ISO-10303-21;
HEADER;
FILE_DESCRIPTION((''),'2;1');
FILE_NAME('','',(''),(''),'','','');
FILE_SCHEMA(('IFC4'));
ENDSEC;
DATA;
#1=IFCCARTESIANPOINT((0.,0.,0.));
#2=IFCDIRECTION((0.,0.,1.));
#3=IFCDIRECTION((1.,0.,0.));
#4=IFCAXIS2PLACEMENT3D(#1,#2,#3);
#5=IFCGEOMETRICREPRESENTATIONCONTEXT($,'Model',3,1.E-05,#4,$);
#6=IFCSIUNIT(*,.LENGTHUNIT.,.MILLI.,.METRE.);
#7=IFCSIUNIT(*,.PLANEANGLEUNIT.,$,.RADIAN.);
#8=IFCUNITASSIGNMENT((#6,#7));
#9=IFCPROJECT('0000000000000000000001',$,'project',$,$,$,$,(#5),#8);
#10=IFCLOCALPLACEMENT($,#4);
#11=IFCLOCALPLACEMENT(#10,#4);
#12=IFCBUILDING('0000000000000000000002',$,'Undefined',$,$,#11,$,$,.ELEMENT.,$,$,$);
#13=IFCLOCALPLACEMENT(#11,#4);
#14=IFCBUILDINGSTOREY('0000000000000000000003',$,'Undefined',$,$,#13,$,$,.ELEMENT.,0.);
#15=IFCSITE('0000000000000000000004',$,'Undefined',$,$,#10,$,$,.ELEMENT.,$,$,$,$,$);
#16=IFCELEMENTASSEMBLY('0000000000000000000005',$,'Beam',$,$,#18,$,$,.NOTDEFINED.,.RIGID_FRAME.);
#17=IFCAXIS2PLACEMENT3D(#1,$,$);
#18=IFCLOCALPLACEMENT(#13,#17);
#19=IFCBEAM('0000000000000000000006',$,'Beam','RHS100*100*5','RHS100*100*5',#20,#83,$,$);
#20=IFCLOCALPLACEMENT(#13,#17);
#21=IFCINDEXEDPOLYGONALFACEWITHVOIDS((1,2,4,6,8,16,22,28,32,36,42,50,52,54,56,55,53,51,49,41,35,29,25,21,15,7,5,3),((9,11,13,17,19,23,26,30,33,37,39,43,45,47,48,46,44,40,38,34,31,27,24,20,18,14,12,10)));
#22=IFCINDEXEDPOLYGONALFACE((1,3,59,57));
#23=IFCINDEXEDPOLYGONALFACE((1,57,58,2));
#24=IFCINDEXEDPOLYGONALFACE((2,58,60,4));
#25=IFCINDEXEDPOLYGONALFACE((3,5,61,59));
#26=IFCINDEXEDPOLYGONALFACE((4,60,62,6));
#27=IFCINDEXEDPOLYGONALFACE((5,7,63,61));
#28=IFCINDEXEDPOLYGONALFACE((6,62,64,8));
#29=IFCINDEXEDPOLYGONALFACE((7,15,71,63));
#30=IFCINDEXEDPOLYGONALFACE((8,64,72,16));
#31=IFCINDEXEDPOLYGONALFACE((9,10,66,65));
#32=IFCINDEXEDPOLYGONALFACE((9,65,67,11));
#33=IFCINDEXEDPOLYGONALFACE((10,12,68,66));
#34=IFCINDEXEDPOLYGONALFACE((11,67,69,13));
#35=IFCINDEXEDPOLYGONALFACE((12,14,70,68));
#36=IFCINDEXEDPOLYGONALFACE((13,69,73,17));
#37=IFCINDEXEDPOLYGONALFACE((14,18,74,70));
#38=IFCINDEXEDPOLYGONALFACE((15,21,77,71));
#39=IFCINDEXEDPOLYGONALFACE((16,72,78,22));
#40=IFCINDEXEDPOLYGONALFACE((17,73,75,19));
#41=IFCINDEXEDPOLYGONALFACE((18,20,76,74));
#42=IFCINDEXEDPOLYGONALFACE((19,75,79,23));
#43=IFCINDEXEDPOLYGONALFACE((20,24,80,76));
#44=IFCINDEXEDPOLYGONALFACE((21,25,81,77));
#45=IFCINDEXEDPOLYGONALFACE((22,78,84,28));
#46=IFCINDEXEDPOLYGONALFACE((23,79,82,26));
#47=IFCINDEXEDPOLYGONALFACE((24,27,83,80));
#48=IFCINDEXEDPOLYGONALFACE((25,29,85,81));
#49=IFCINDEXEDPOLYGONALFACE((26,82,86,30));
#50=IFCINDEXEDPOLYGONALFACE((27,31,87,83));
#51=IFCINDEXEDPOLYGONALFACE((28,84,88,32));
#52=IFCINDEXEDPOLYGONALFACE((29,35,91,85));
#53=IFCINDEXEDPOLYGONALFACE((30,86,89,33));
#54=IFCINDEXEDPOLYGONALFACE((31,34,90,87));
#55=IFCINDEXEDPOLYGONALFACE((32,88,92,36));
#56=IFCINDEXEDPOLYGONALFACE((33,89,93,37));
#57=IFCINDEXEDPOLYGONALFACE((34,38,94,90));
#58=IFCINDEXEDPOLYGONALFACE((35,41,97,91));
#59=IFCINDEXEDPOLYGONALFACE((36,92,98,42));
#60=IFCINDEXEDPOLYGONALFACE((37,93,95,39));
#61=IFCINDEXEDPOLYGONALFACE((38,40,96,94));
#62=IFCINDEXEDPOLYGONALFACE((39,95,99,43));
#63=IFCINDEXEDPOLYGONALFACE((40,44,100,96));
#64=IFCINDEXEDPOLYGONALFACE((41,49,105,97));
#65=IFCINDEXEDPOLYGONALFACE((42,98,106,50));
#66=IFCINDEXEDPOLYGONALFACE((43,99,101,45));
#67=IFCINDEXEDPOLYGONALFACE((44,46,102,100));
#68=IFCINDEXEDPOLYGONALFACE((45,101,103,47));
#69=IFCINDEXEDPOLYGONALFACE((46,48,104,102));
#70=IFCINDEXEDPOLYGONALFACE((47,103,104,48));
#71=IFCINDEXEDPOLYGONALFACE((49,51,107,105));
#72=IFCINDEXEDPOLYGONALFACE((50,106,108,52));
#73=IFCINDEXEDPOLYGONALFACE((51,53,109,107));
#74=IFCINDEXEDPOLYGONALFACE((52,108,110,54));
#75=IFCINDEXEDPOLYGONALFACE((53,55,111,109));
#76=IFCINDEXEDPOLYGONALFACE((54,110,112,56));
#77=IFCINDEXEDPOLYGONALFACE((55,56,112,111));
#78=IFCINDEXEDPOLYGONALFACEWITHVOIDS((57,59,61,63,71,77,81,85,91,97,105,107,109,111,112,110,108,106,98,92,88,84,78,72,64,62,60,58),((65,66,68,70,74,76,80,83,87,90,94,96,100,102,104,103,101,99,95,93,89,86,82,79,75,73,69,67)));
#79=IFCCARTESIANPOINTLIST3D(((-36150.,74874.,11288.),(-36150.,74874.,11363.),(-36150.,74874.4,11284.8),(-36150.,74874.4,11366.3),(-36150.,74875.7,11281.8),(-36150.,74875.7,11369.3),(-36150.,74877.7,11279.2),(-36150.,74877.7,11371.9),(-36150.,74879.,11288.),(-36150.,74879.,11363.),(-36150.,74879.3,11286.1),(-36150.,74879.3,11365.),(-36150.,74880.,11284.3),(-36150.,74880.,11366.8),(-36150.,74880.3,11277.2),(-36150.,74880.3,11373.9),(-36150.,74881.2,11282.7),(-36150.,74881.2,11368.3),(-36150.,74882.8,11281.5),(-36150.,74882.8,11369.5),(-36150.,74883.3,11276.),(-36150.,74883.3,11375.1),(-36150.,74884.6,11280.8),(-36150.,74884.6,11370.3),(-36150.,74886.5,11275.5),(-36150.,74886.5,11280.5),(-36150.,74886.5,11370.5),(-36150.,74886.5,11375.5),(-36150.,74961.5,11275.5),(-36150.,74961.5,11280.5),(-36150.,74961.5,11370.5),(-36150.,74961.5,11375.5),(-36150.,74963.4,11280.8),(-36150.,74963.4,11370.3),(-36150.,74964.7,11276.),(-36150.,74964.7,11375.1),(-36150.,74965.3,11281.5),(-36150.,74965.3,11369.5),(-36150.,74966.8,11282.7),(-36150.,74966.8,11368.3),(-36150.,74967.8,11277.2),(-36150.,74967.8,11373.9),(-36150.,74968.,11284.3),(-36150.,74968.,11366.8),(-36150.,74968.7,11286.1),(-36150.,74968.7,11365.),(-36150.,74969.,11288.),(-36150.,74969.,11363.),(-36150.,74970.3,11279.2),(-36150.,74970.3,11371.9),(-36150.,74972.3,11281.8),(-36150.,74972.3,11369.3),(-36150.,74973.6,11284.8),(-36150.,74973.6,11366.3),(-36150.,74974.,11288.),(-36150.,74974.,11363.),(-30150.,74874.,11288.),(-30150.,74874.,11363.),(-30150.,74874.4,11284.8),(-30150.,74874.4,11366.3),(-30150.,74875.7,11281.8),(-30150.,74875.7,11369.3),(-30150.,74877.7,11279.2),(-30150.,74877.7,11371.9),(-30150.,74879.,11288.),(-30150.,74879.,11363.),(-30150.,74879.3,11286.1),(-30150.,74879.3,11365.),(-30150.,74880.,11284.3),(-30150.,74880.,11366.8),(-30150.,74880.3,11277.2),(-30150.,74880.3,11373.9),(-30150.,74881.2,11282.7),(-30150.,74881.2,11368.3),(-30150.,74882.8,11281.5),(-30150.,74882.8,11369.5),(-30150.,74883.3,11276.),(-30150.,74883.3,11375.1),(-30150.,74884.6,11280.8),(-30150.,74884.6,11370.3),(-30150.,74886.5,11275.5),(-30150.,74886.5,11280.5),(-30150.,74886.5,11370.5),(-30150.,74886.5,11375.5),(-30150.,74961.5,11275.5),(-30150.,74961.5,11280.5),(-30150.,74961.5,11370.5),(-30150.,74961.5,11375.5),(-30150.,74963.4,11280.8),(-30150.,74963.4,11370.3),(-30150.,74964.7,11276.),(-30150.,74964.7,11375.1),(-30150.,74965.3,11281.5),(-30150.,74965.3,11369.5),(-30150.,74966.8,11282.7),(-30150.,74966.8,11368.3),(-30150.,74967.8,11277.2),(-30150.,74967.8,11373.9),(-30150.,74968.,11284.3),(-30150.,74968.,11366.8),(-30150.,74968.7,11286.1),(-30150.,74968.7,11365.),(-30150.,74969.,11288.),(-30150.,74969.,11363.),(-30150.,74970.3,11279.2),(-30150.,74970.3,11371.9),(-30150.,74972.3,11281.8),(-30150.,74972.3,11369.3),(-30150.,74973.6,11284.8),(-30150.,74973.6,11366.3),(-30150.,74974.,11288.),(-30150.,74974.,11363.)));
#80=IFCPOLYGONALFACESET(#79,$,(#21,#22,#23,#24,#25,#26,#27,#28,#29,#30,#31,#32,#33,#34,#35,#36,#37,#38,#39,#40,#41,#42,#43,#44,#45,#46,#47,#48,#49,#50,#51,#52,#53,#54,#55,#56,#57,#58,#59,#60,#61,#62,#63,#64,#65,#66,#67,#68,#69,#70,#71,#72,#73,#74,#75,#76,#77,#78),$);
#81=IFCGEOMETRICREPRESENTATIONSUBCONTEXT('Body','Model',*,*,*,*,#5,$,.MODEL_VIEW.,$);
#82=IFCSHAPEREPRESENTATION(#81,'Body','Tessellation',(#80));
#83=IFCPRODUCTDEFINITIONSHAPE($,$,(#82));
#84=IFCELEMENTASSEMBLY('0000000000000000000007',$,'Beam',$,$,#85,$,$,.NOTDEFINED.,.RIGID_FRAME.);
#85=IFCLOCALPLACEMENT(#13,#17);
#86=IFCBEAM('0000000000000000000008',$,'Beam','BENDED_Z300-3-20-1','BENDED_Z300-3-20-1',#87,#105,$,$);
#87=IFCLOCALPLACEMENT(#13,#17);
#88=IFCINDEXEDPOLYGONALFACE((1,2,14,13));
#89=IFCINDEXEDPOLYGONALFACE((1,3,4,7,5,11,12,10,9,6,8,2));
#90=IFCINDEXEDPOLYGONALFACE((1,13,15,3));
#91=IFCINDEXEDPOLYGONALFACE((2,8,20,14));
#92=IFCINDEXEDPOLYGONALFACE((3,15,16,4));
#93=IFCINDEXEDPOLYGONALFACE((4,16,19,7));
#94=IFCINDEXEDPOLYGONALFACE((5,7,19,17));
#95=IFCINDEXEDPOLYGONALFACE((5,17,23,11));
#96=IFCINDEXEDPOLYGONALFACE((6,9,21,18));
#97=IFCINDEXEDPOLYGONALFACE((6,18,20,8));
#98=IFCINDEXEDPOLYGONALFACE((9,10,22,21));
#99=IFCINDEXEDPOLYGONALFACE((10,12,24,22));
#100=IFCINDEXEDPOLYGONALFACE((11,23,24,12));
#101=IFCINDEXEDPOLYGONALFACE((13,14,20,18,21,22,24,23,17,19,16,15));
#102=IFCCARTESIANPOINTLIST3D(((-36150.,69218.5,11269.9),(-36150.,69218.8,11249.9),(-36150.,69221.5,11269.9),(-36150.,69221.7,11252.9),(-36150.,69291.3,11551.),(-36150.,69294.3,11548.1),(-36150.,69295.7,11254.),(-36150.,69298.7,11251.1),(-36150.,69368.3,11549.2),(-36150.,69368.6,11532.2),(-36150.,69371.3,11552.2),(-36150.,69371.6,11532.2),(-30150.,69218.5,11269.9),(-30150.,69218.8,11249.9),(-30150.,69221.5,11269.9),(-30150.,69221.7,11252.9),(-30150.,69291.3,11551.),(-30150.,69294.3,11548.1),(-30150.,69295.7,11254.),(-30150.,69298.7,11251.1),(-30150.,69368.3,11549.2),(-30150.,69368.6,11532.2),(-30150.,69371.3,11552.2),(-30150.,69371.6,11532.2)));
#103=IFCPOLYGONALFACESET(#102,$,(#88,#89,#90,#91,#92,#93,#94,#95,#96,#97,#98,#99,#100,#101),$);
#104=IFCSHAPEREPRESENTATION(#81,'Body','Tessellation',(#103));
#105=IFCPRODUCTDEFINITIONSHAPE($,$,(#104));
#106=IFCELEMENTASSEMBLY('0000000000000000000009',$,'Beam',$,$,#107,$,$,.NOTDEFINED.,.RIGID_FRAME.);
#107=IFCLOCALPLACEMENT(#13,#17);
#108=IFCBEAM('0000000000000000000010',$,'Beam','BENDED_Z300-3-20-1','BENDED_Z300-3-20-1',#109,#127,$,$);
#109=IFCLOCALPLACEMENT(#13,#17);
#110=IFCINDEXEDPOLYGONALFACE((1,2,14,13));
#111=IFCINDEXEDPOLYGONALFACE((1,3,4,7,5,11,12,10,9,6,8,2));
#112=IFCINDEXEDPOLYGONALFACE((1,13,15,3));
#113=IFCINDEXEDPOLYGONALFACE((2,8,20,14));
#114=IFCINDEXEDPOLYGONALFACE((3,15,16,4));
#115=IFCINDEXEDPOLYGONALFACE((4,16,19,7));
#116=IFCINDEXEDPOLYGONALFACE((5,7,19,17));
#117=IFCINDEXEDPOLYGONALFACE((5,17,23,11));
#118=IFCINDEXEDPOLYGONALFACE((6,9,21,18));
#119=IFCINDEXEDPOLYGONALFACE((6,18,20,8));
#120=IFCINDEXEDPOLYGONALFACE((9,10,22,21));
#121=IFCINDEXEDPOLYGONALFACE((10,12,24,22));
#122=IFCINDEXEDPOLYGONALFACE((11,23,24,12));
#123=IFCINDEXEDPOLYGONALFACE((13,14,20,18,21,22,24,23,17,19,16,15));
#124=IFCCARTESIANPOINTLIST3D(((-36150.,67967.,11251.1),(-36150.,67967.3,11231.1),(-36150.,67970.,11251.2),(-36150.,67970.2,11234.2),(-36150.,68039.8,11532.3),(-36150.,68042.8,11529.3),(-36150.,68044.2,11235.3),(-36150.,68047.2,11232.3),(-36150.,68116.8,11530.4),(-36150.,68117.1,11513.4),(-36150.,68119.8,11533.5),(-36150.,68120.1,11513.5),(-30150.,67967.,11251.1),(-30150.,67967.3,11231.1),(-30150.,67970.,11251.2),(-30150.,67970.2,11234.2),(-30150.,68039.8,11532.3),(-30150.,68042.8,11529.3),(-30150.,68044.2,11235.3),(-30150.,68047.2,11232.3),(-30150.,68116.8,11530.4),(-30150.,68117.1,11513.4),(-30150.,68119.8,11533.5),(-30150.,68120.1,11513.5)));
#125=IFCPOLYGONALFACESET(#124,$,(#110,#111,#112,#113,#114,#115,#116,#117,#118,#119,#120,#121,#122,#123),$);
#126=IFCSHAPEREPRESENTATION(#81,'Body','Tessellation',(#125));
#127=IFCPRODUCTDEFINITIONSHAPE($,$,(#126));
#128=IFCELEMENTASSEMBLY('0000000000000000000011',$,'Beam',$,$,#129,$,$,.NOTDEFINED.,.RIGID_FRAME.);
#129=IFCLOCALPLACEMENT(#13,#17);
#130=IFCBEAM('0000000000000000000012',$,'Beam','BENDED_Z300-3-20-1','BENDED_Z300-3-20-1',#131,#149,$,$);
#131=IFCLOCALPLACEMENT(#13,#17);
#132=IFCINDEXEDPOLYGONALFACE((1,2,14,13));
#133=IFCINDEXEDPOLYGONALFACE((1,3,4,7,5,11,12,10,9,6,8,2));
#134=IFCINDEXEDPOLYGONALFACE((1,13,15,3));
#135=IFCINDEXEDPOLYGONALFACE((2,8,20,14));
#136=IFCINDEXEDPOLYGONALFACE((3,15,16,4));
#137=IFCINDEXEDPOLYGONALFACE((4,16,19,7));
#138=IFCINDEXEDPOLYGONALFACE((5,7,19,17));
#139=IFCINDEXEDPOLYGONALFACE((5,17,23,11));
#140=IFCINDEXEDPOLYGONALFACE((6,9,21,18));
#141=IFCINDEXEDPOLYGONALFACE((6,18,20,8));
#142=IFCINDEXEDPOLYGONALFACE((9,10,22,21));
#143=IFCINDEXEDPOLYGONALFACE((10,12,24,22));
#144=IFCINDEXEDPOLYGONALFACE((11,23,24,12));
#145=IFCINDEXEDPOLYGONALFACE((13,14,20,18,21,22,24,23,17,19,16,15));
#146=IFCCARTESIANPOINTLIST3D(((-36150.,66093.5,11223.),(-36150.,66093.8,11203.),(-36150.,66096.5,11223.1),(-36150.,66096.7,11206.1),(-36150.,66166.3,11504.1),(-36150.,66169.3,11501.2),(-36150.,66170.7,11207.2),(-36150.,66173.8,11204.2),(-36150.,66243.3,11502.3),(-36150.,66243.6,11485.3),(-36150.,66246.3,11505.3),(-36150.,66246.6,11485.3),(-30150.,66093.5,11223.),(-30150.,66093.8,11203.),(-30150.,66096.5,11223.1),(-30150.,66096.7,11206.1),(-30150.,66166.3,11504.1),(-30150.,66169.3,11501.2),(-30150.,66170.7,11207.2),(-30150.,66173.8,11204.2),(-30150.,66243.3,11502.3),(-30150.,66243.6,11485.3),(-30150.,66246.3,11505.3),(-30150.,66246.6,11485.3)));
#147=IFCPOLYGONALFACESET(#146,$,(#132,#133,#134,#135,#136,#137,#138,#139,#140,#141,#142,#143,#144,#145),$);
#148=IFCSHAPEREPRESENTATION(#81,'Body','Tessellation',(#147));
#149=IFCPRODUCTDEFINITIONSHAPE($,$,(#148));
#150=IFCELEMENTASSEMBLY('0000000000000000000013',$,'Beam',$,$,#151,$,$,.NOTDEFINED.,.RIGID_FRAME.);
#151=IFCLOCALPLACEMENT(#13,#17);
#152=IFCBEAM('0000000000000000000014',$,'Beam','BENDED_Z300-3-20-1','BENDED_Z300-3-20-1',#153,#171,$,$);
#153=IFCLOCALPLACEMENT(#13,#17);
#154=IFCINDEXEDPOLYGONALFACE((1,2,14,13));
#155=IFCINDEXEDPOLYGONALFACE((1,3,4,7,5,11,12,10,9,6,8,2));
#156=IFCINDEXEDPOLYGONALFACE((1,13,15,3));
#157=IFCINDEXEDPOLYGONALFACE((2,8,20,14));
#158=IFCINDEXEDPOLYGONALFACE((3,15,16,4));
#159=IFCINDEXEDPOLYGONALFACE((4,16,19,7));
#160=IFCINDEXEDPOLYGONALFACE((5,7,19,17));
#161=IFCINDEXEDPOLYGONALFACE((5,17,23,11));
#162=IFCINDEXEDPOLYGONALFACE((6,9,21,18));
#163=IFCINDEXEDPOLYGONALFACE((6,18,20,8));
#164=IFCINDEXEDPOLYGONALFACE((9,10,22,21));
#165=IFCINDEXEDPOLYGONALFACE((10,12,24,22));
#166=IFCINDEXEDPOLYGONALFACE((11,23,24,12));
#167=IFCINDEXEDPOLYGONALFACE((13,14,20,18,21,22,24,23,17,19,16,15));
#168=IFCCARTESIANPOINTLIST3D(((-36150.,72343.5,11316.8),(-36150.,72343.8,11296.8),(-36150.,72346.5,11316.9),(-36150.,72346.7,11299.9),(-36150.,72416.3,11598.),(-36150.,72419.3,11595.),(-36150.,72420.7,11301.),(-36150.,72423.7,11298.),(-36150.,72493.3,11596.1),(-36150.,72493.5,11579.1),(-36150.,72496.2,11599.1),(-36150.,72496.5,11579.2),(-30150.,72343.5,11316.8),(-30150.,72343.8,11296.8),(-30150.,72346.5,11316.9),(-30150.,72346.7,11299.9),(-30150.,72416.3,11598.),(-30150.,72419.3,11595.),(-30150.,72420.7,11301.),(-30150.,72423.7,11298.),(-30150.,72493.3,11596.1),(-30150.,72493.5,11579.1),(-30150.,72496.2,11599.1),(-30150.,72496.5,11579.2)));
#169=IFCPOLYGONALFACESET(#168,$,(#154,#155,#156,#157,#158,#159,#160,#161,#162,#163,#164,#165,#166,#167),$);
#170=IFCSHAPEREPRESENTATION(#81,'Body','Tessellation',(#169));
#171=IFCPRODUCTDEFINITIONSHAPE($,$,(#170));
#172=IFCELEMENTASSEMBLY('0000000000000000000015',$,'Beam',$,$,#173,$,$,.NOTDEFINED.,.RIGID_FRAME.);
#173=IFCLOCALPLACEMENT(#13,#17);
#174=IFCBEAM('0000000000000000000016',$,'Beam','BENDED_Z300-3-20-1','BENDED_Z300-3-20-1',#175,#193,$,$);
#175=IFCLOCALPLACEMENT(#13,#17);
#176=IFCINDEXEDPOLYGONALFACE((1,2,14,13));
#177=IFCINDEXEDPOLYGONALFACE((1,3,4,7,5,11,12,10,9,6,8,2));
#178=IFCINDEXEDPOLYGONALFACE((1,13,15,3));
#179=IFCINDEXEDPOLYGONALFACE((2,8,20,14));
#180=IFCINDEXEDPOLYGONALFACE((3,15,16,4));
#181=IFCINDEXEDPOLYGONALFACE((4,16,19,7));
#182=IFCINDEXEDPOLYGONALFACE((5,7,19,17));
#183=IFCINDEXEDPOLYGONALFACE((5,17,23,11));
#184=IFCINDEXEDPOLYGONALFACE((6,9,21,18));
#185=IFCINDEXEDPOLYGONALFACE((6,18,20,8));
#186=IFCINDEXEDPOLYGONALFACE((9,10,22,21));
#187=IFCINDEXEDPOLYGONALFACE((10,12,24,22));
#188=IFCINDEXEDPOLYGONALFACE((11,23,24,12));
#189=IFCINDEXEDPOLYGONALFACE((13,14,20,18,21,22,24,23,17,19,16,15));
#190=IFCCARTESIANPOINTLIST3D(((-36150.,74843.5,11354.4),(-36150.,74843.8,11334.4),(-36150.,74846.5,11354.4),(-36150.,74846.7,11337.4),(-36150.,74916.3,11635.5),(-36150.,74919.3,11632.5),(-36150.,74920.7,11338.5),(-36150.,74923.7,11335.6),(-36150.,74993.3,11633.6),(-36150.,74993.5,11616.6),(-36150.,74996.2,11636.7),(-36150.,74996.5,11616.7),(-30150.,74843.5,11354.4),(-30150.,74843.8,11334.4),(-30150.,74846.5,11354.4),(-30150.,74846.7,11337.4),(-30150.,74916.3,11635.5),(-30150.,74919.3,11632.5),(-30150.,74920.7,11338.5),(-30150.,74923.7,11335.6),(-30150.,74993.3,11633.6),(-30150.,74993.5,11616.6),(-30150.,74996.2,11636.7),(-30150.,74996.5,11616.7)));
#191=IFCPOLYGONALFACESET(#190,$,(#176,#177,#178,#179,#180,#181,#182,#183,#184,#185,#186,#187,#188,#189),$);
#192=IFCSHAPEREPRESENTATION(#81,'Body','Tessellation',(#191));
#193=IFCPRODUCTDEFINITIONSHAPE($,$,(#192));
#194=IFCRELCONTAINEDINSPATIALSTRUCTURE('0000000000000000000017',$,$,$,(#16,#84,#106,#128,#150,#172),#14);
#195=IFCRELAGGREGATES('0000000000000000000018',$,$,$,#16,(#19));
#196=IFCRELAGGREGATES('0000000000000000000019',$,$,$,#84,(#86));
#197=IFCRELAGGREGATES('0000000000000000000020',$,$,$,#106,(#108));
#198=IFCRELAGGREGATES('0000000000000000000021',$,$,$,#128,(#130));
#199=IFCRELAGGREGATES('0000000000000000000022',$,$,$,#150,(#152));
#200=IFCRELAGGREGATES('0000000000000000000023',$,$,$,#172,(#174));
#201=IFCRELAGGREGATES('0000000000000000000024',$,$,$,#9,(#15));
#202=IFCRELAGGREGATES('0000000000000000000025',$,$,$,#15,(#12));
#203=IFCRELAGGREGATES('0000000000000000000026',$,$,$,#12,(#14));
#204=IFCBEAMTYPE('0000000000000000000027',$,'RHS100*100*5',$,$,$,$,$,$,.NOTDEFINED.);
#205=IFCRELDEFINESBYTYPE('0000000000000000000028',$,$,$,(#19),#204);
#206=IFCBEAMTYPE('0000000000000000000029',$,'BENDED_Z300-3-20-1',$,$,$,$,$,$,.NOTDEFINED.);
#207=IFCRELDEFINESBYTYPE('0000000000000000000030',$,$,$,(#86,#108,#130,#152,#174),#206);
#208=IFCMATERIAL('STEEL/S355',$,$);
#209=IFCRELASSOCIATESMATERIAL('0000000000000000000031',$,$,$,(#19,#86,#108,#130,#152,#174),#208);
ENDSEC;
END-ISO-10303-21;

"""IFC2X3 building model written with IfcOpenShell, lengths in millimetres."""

from ifc_helpers import new_model, si_unit, frame, origin_with_axes, origin_2d_with_axis, place, context, subcontext, project, spatial, polyline, hollow_rectangle, outline, extrude, material, type_object, element, aggregate, save


model = new_model("IFC2X3")

# Units and contexts
model_context = context("Model", 3, precision=1e-05, world=origin_with_axes())
body_context = subcontext(model_context, "Body", "Model", "MODEL_VIEW")
ifc_project = project(units=[si_unit("LENGTHUNIT", "METRE", prefix="MILLI"), si_unit("PLANEANGLEUNIT", "RADIAN")], contexts=[model_context])

# Site, building, storey
site_placement = place(None, origin_with_axes())
site = spatial("IfcSite", under=ifc_project, at=site_placement, Name="Undefined", CompositionType="ELEMENT")
building_placement = place(site_placement, origin_with_axes())
building = spatial("IfcBuilding", under=site, at=building_placement, Name="Undefined", CompositionType="ELEMENT")
storey_placement = place(building_placement, origin_with_axes())
storey = spatial("IfcBuildingStorey", under=building, at=storey_placement, Name="Undefined", CompositionType="ELEMENT", Elevation=0.0)

# Shared definitions
ifc_material = material(Name="STEEL/S355")

# Element assemblies, beams
beam_type_1 = type_object("IfcBeamType", Name="RHS100*100*5", PredefinedType="NOTDEFINED")
assembly_1_placement = place(storey_placement, origin_with_axes())
assembly_1 = element("IfcElementAssembly", 1, at=assembly_1_placement, inside=storey, Name="Beam", AssemblyPlace="NOTDEFINED", PredefinedType="RIGID_FRAME")
beam_1_placement = place(assembly_1_placement, frame((-30150.0, 74924.0, 11325.5), z_axis=(0.0, 0.0, 1.0), x_axis=(-1.0, 0.0, 0.0)))
beam_1 = element("IfcBeam", 2, at=beam_1_placement, type_object=beam_type_1, material=ifc_material, Name="Beam", Description="RHS100*100*5", ObjectType="RHS100*100*5", context=body_context, shape_type="SweptSolid", body=[
    extrude(hollow_rectangle(XDim=100.0, YDim=100.0, WallThickness=5.0, InnerFilletRadius=7.5, OuterFilletRadius=12.5, at=origin_2d_with_axis()), frame((6000.0, 0.0, 0.0), z_axis=(-1.0, 0.0, 0.0), x_axis=(0.0, -1.0, 0.0)), (0.0, 0.0, 1.0), 6000.0),
])
aggregate(assembly_1, [beam_1])
assembly_2_placement = place(storey_placement, origin_with_axes())
assembly_2 = element("IfcElementAssembly", 3, at=assembly_2_placement, inside=storey, Name="Beam", AssemblyPlace="NOTDEFINED", PredefinedType="RIGID_FRAME")
beam_type_2 = type_object("IfcBeamType", Name="BENDED_Z300-3-20-1", PredefinedType="NOTDEFINED")
beam_2_placement = place(assembly_2_placement, frame((-30150.0, 69295.0, 11401.1), z_axis=(0.0, -0.014963, 0.999888), x_axis=(-1.0, 0.0, 0.0)))
beam_2 = element("IfcBeam", 4, at=beam_2_placement, type_object=beam_type_2, material=ifc_material, Name="Beam", Description="BENDED_Z300-3-20-1", ObjectType="BENDED_Z300-3-20-1", context=body_context, shape_type="SweptSolid", body=[
    extrude(outline(polyline([(1.5, -150.0), (-78.5, -150.0), (-78.5, -130.0), (-75.5, -130.0), (-75.5, -147.0), (-1.5, -147.0), (-1.5, 150.0), (78.5, 150.0), (78.5, 130.0), (75.5, 130.0), (75.5, 147.0), (1.5, 147.0), (1.5, -150.0)])), frame((6000.0, 0.0, 0.0), z_axis=(-1.0, 0.0, 0.0), x_axis=(0.0, -1.0, 0.0)), (0.0, 0.0, 1.0), 6000.0),
])
aggregate(assembly_2, [beam_2])
assembly_3_placement = place(storey_placement, origin_with_axes())
assembly_3 = element("IfcElementAssembly", 5, at=assembly_3_placement, inside=storey, Name="Beam", AssemblyPlace="NOTDEFINED", PredefinedType="RIGID_FRAME")
beam_3_placement = place(assembly_3_placement, frame((-30150.0, 68043.5, 11382.3), z_axis=(0.0, -0.014963, 0.999888), x_axis=(-1.0, 0.0, 0.0)))
beam_3 = element("IfcBeam", 6, at=beam_3_placement, type_object=beam_type_2, material=ifc_material, Name="Beam", Description="BENDED_Z300-3-20-1", ObjectType="BENDED_Z300-3-20-1", context=body_context, shape_type="SweptSolid", body=[
    extrude(outline(polyline([(1.5, -150.0), (-78.5, -150.0), (-78.5, -130.0), (-75.5, -130.0), (-75.5, -147.0), (-1.5, -147.0), (-1.5, 150.0), (78.5, 150.0), (78.5, 130.0), (75.5, 130.0), (75.5, 147.0), (1.5, 147.0), (1.5, -150.0)])), frame((6000.0, 0.0, 0.0), z_axis=(-1.0, 0.0, 0.0), x_axis=(0.0, -1.0, 0.0)), (0.0, 0.0, 1.0), 6000.0),
])
aggregate(assembly_3, [beam_3])
assembly_4_placement = place(storey_placement, origin_with_axes())
assembly_4 = element("IfcElementAssembly", 7, at=assembly_4_placement, inside=storey, Name="Beam", AssemblyPlace="NOTDEFINED", PredefinedType="RIGID_FRAME")
beam_4_placement = place(assembly_4_placement, frame((-30150.0, 66170.0, 11354.2), z_axis=(0.0, -0.014963, 0.999888), x_axis=(-1.0, 0.0, 0.0)))
beam_4 = element("IfcBeam", 8, at=beam_4_placement, type_object=beam_type_2, material=ifc_material, Name="Beam", Description="BENDED_Z300-3-20-1", ObjectType="BENDED_Z300-3-20-1", context=body_context, shape_type="SweptSolid", body=[
    extrude(outline(polyline([(1.5, -150.0), (-78.5, -150.0), (-78.5, -130.0), (-75.5, -130.0), (-75.5, -147.0), (-1.5, -147.0), (-1.5, 150.0), (78.5, 150.0), (78.5, 130.0), (75.5, 130.0), (75.5, 147.0), (1.5, 147.0), (1.5, -150.0)])), frame((6000.0, 0.0, 0.0), z_axis=(-1.0, 0.0, 0.0), x_axis=(0.0, -1.0, 0.0)), (0.0, 0.0, 1.0), 6000.0),
])
aggregate(assembly_4, [beam_4])
assembly_5_placement = place(storey_placement, origin_with_axes())
assembly_5 = element("IfcElementAssembly", 9, at=assembly_5_placement, inside=storey, Name="Beam", AssemblyPlace="NOTDEFINED", PredefinedType="RIGID_FRAME")
beam_5_placement = place(assembly_5_placement, frame((-30150.0, 72420.0, 11448.0), z_axis=(0.0, -0.014963, 0.999888), x_axis=(-1.0, 0.0, 0.0)))
beam_5 = element("IfcBeam", 10, at=beam_5_placement, type_object=beam_type_2, material=ifc_material, Name="Beam", Description="BENDED_Z300-3-20-1", ObjectType="BENDED_Z300-3-20-1", context=body_context, shape_type="SweptSolid", body=[
    extrude(outline(polyline([(1.5, -150.0), (-78.5, -150.0), (-78.5, -130.0), (-75.5, -130.0), (-75.5, -147.0), (-1.5, -147.0), (-1.5, 150.0), (78.5, 150.0), (78.5, 130.0), (75.5, 130.0), (75.5, 147.0), (1.5, 147.0), (1.5, -150.0)])), frame((6000.0, 0.0, 0.0), z_axis=(-1.0, 0.0, 0.0), x_axis=(0.0, -1.0, 0.0)), (0.0, 0.0, 1.0), 6000.0),
])
aggregate(assembly_5, [beam_5])
assembly_6_placement = place(storey_placement, origin_with_axes())
assembly_6 = element("IfcElementAssembly", 11, at=assembly_6_placement, inside=storey, Name="Beam", AssemblyPlace="NOTDEFINED", PredefinedType="RIGID_FRAME")
beam_6_placement = place(assembly_6_placement, frame((-30150.0, 74920.0, 11485.5), z_axis=(0.0, -0.014963, 0.999888), x_axis=(-1.0, 0.0, 0.0)))
beam_6 = element("IfcBeam", 12, at=beam_6_placement, type_object=beam_type_2, material=ifc_material, Name="Beam", Description="BENDED_Z300-3-20-1", ObjectType="BENDED_Z300-3-20-1", context=body_context, shape_type="SweptSolid", body=[
    extrude(outline(polyline([(1.5, -150.0), (-78.5, -150.0), (-78.5, -130.0), (-75.5, -130.0), (-75.5, -147.0), (-1.5, -147.0), (-1.5, 150.0), (78.5, 150.0), (78.5, 130.0), (75.5, 130.0), (75.5, 147.0), (1.5, 147.0), (1.5, -150.0)])), frame((6000.0, 0.0, 0.0), z_axis=(-1.0, 0.0, 0.0), x_axis=(0.0, -1.0, 0.0)), (0.0, 0.0, 1.0), 6000.0),
])
aggregate(assembly_6, [beam_6])

save(model, "model.ifc")
